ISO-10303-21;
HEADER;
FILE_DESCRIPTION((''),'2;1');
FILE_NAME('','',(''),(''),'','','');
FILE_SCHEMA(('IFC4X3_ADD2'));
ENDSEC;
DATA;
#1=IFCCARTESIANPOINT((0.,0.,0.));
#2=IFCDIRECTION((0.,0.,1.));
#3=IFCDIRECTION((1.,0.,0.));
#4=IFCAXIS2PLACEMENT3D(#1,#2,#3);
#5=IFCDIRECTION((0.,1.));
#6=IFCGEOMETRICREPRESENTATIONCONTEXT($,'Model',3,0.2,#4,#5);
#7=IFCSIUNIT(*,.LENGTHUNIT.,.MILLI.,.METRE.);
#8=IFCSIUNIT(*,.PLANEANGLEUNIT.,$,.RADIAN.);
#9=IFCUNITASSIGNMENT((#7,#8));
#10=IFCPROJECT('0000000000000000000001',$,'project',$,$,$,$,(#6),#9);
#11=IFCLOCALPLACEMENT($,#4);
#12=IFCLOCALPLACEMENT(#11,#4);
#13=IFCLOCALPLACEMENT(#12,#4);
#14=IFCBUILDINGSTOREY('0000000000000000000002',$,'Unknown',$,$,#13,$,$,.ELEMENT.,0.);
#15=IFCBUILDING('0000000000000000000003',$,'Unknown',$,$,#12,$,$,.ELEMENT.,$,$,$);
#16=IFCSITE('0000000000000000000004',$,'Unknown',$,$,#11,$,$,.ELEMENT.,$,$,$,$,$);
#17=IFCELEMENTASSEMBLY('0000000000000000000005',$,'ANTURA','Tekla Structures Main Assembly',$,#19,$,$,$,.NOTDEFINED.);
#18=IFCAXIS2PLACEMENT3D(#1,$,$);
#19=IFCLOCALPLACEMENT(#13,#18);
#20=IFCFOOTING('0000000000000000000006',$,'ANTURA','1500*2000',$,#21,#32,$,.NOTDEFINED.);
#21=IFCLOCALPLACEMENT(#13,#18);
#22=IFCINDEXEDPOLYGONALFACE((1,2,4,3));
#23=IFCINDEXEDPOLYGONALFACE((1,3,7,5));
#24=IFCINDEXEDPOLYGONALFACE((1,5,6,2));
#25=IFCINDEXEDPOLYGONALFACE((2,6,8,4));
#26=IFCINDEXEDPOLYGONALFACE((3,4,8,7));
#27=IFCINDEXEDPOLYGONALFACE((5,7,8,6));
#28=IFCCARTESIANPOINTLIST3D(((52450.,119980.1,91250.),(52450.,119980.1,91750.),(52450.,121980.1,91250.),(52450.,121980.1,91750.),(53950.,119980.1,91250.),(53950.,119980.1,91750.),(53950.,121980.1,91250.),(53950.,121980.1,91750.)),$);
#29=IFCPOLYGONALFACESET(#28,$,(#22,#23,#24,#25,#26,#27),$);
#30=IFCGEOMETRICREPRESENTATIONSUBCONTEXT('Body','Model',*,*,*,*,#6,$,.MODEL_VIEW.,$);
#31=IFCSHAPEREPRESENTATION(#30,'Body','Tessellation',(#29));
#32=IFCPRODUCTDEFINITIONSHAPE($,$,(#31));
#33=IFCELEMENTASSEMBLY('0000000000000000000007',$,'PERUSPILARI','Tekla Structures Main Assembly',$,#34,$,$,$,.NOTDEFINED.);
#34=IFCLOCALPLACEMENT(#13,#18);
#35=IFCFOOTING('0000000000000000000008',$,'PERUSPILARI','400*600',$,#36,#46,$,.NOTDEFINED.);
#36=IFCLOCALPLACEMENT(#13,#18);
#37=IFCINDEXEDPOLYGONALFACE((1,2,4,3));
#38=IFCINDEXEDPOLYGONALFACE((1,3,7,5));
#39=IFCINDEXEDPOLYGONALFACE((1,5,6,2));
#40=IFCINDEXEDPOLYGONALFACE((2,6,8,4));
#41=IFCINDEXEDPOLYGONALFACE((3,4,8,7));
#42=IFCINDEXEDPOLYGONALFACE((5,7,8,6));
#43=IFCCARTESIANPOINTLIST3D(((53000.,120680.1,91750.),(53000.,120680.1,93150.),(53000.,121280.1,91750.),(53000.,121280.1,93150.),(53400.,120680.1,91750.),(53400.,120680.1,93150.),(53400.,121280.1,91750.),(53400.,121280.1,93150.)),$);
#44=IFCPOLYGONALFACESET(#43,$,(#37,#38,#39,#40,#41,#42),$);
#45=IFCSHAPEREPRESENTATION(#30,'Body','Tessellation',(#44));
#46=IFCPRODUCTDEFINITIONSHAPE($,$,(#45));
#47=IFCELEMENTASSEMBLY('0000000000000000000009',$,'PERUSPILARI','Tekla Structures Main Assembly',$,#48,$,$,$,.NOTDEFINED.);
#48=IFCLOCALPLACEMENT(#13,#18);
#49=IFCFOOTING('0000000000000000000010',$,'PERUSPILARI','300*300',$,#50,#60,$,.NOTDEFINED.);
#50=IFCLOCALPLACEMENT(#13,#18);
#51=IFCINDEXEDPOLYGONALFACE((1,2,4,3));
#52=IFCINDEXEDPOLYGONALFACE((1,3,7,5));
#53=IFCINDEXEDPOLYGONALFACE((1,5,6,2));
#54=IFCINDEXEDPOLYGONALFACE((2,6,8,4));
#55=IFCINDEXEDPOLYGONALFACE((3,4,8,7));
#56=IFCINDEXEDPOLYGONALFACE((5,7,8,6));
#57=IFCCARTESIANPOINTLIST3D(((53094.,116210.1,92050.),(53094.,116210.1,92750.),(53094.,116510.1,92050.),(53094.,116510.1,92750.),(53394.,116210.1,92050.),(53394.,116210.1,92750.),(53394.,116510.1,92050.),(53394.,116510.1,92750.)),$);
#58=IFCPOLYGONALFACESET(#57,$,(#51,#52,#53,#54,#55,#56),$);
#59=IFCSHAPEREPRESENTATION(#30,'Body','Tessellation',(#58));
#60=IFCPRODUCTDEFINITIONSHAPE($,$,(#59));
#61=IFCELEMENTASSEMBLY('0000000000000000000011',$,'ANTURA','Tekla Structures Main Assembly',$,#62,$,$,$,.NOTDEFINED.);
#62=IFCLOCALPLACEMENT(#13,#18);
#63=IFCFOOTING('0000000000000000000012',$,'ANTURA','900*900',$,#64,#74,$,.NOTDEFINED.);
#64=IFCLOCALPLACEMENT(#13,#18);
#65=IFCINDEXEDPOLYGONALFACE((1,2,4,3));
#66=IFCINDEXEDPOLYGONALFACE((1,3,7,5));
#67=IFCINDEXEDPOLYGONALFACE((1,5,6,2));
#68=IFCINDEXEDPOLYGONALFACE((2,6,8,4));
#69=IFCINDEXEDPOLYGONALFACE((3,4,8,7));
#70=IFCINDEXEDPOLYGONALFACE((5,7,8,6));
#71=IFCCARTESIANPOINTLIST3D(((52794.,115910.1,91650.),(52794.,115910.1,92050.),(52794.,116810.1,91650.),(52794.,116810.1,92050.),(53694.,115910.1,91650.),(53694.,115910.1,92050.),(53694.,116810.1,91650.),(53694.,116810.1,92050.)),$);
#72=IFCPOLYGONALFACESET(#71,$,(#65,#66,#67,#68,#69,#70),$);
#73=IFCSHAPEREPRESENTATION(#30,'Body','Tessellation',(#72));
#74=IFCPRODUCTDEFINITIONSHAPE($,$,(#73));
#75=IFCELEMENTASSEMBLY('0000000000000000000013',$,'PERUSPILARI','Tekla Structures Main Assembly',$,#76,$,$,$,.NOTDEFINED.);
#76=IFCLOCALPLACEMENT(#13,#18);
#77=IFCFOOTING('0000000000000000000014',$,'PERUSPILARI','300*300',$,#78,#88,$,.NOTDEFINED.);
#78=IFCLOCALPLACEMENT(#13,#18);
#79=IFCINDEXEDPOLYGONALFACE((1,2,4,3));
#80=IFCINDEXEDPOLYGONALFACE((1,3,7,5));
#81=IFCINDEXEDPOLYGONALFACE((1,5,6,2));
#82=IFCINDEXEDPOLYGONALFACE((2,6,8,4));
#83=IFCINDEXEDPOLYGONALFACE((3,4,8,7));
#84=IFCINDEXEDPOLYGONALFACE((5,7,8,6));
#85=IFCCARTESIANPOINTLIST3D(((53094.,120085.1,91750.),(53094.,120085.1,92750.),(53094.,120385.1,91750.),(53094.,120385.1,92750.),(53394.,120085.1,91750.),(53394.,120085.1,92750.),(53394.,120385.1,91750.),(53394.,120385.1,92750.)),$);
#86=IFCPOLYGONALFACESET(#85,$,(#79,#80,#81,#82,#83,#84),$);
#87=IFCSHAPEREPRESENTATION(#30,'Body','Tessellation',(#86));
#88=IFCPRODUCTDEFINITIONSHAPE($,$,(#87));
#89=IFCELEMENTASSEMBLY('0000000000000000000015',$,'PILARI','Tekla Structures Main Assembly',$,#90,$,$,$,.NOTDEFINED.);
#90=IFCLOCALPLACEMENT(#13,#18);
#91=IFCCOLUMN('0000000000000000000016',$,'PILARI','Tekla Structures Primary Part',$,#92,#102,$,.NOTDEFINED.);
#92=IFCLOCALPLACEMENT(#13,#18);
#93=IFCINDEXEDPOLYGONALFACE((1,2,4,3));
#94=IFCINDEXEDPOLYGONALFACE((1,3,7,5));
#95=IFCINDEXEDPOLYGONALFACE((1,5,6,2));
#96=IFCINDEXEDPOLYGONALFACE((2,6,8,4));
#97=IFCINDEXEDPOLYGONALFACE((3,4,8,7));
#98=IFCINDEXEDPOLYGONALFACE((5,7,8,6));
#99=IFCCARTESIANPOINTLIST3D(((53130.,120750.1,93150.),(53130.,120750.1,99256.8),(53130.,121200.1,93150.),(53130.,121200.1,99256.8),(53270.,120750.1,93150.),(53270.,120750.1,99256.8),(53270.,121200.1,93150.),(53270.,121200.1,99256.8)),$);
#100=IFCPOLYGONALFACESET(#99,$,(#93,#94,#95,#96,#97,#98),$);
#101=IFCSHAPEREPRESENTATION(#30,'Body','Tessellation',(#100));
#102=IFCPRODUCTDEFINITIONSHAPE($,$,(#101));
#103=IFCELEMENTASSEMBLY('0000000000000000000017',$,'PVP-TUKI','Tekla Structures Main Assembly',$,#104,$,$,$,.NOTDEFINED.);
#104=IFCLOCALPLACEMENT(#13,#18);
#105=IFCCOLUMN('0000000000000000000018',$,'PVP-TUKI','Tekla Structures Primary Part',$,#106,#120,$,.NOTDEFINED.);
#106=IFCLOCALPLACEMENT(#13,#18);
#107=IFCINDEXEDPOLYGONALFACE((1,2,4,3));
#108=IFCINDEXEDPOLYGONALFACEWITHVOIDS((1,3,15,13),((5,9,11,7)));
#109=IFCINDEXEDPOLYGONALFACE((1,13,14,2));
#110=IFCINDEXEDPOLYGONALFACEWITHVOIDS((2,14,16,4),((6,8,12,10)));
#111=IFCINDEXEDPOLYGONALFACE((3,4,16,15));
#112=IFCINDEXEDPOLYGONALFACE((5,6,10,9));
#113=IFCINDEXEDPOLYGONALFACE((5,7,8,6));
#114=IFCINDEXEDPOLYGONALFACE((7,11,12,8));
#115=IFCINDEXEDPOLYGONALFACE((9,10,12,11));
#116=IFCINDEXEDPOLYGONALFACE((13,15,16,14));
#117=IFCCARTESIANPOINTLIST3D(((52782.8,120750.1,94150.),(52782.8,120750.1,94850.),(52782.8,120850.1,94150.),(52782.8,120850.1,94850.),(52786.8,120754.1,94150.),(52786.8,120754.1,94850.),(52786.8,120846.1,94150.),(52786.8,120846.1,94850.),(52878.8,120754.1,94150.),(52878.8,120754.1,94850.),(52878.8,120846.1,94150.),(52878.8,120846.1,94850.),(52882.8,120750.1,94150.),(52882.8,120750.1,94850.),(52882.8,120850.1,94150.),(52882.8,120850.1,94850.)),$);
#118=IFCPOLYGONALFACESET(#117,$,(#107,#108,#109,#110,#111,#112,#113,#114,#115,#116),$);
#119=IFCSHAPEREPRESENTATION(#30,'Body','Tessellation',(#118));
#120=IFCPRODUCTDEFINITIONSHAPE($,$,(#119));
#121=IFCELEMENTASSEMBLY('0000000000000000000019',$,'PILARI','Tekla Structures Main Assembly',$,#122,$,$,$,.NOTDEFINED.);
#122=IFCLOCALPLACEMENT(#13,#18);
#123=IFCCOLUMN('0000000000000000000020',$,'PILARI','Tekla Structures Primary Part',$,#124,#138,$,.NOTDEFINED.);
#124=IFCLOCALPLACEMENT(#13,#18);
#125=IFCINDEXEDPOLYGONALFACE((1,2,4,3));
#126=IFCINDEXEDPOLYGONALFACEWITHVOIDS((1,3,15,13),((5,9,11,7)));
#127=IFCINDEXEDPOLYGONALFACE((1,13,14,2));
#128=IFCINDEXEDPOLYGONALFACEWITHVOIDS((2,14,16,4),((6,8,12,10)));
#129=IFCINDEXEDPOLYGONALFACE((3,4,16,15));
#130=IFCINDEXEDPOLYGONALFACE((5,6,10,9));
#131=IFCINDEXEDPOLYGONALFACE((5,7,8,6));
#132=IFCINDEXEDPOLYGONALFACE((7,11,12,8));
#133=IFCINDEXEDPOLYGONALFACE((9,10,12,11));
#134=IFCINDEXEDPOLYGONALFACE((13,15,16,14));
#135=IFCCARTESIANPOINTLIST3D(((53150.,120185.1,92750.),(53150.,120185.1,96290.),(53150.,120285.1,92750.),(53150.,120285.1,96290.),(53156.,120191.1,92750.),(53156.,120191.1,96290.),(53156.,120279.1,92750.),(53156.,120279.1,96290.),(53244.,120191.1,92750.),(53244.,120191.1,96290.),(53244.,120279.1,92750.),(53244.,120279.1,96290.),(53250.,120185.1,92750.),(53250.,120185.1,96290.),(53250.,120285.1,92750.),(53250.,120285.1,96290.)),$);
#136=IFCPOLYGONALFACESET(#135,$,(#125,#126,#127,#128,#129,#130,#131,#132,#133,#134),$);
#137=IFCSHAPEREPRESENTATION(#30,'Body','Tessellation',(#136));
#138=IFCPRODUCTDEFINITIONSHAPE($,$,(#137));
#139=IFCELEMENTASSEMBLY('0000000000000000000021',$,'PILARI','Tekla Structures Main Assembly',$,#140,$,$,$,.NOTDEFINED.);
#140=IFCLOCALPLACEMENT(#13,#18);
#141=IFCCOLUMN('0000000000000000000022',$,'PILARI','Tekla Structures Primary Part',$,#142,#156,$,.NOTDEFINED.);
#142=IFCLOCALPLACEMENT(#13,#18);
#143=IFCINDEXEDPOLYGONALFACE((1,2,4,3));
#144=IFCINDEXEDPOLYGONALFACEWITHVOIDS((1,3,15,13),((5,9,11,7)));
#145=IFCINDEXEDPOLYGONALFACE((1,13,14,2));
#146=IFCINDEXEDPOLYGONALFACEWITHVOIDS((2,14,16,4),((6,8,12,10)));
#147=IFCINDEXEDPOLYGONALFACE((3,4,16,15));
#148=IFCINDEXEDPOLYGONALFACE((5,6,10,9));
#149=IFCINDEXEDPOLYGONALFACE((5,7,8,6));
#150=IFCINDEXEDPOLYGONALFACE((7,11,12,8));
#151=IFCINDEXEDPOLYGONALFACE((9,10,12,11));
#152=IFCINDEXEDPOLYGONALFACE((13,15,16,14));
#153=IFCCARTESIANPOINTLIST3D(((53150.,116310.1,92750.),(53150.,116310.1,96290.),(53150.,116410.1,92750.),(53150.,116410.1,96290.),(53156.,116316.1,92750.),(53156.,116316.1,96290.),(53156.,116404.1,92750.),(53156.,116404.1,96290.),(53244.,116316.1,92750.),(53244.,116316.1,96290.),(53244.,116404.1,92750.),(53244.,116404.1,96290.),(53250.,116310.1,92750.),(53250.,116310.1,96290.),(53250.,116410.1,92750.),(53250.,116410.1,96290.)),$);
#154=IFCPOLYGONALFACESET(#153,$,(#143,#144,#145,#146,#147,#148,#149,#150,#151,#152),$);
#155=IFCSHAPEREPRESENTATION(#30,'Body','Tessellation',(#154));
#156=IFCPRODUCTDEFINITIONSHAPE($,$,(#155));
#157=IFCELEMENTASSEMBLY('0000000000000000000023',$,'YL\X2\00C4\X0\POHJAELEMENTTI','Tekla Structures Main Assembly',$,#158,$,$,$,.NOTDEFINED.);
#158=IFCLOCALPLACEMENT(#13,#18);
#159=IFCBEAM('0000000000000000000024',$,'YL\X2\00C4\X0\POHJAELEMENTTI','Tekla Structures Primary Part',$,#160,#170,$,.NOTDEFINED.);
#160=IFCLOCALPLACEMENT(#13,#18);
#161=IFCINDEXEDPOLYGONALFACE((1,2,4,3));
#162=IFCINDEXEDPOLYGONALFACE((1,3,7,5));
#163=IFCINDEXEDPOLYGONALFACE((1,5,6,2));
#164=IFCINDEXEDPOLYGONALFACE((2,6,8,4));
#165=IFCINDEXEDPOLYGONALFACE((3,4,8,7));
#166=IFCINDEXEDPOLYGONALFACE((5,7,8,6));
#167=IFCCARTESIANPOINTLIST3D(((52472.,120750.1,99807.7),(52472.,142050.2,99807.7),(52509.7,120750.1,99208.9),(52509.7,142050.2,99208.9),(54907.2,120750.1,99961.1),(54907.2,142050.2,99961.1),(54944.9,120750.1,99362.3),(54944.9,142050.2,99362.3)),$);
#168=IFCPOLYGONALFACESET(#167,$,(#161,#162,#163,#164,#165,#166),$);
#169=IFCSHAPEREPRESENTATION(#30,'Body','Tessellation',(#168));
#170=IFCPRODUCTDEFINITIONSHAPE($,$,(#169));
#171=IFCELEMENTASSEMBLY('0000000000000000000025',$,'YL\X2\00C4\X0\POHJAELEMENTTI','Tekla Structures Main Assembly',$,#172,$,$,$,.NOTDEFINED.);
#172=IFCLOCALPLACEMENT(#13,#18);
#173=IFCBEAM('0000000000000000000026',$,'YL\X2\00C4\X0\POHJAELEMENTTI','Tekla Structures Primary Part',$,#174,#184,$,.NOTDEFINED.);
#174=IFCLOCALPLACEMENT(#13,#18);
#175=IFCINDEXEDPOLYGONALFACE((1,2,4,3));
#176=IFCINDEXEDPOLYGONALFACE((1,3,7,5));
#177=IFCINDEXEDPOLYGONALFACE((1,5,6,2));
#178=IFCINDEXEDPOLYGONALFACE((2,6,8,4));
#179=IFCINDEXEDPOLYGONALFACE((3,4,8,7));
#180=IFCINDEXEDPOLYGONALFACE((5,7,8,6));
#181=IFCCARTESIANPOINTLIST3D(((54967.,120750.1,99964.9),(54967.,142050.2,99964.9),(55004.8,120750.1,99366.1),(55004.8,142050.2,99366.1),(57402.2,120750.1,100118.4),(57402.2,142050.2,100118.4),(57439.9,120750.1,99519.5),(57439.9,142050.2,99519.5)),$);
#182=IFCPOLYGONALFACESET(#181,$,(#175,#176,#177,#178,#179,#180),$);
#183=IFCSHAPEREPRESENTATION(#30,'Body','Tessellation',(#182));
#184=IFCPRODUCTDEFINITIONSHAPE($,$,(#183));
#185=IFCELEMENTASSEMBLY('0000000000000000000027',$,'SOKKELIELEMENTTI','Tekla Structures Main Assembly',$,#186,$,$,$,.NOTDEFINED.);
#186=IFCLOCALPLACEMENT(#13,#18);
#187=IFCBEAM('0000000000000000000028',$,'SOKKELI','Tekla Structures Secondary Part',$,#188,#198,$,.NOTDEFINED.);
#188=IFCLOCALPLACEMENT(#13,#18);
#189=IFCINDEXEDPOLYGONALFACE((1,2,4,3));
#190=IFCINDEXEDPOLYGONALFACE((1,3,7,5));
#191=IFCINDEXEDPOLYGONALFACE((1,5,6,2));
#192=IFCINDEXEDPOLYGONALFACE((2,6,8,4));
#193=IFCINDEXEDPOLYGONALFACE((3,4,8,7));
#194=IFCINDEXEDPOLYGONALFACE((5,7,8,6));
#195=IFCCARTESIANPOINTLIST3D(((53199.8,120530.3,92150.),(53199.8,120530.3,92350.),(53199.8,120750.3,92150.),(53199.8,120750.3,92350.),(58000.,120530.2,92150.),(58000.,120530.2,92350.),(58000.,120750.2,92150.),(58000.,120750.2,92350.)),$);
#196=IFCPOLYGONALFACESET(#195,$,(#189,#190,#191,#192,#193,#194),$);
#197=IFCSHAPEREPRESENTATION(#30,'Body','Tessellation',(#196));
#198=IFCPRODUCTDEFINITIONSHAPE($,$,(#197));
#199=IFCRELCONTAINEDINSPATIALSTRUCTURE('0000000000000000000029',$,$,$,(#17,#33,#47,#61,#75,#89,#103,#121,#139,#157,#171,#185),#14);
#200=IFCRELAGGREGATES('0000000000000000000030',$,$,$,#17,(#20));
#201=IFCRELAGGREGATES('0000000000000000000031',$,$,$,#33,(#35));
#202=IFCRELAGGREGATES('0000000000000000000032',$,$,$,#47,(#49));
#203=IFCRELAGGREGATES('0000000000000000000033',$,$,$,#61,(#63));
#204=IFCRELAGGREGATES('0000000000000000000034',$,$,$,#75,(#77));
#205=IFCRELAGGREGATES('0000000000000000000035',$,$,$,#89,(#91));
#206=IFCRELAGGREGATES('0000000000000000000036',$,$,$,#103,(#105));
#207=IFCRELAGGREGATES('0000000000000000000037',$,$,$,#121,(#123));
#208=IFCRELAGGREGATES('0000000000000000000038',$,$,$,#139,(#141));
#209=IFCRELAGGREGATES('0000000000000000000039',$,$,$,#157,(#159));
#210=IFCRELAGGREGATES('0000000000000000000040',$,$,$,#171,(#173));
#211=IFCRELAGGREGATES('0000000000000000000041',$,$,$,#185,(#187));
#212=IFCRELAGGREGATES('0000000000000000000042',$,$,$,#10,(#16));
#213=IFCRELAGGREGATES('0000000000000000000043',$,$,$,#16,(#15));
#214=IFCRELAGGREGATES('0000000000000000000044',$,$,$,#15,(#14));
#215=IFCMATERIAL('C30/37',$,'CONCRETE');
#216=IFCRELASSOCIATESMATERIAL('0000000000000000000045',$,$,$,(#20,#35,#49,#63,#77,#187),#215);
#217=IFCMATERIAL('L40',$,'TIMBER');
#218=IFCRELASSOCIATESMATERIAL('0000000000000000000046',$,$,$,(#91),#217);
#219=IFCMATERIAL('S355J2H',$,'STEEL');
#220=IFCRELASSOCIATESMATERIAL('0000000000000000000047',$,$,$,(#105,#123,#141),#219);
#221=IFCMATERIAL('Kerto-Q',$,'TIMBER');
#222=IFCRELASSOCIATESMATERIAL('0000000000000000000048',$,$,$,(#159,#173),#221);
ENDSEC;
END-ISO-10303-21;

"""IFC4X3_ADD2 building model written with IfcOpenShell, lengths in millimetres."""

from ifc_helpers import new_model, si_unit, direction, frame, origin_with_axes, place, context, subcontext, project, spatial, line, indexed_curve, outline, extrude, material, element, aggregate, save


model = new_model("IFC4X3_ADD2")

# Units and contexts
model_context = context("Model", 3, precision=0.2, world=origin_with_axes(), true_north=direction((0.0, 1.0)))
body_context = subcontext(model_context, "Body", "Model", "MODEL_VIEW")
ifc_project = project(units=[si_unit("LENGTHUNIT", "METRE", prefix="MILLI"), si_unit("PLANEANGLEUNIT", "RADIAN")], contexts=[model_context])

# Site, building, storey
site_placement = place(None, origin_with_axes())
site = spatial("IfcSite", under=ifc_project, at=site_placement, Name="Unknown", CompositionType="ELEMENT")
building_placement = place(site_placement, origin_with_axes())
building = spatial("IfcBuilding", under=site, at=building_placement, Name="Unknown", CompositionType="ELEMENT")
storey_placement = place(building_placement, origin_with_axes())
storey = spatial("IfcBuildingStorey", under=building, at=storey_placement, Name="Unknown", CompositionType="ELEMENT", Elevation=0.0)

# Element assembly, footing
assembly_1_placement = place(storey_placement, frame((53200.0, 120980.1, 91250.0), z_axis=(0.0, -1.0, 0.0), x_axis=(0.0, 0.0, 1.0)))
assembly_1 = element("IfcElementAssembly", 1, at=assembly_1_placement, inside=storey, Name="ANTURA", Description="Tekla Structures Main Assembly", PredefinedType="NOTDEFINED")
ifc_material_1 = material(Name="C30/37", Category="CONCRETE")
footing_1_placement = place(assembly_1_placement, origin_with_axes())
footing_1 = element("IfcFooting", 2, at=footing_1_placement, material=ifc_material_1, Name="ANTURA", Description="1500*2000", PredefinedType="NOTDEFINED", context=body_context, shape_type="SolidModel", body=[
    extrude(outline(indexed_curve([(-1000.0, -750.0), (1000.0, -750.0), (1000.0, 750.0), (-1000.0, 750.0)], segments=[line(1, 2, 3, 4, 1)])), frame((0.0, 0.0, 0.0), z_axis=(-1.0, 0.0, 0.0), x_axis=(0.0, 0.0, 1.0)), (0.0, 0.0, -1.0), 500.0),
])
aggregate(assembly_1, [footing_1])

# Element assemblies, footings
assembly_2_placement = place(storey_placement, frame((53200.0, 120980.1, 91750.0), z_axis=(0.0, -1.0, 0.0), x_axis=(0.0, 0.0, 1.0)))
assembly_2 = element("IfcElementAssembly", 3, at=assembly_2_placement, inside=storey, Name="PERUSPILARI", Description="Tekla Structures Main Assembly", PredefinedType="NOTDEFINED")
footing_2_placement = place(assembly_2_placement, origin_with_axes())
footing_2 = element("IfcFooting", 4, at=footing_2_placement, material=ifc_material_1, Name="PERUSPILARI", Description="400*600", PredefinedType="NOTDEFINED", context=body_context, shape_type="SolidModel", body=[
    extrude(outline(indexed_curve([(-300.0, -200.0), (300.0, -200.0), (300.0, 200.0), (-300.0, 200.0)], segments=[line(1, 2, 3, 4, 1)])), frame((0.0, 0.0, 0.0), z_axis=(-1.0, 0.0, 0.0), x_axis=(0.0, 0.0, 1.0)), (0.0, 0.0, -1.0), 1400.0),
])
aggregate(assembly_2, [footing_2])
assembly_3_placement = place(storey_placement, frame((53244.0, 116360.1, 92050.0), z_axis=(-1.0, 0.0, 0.0), x_axis=(0.0, 0.0, 1.0)))
assembly_3 = element("IfcElementAssembly", 5, at=assembly_3_placement, inside=storey, Name="PERUSPILARI", Description="Tekla Structures Main Assembly", PredefinedType="NOTDEFINED")
footing_3_placement = place(assembly_3_placement, origin_with_axes())
footing_3 = element("IfcFooting", 6, at=footing_3_placement, material=ifc_material_1, Name="PERUSPILARI", Description="300*300", PredefinedType="NOTDEFINED", context=body_context, shape_type="SolidModel", body=[
    extrude(outline(indexed_curve([(-150.0, -150.0), (150.0, -150.0), (150.0, 150.0), (-150.0, 150.0)], segments=[line(1, 2, 3, 4, 1)])), frame((0.0, 0.0, 0.0), z_axis=(-1.0, 0.0, 0.0), x_axis=(0.0, 0.0, 1.0)), (0.0, 0.0, -1.0), 700.0),
])
aggregate(assembly_3, [footing_3])
assembly_4_placement = place(storey_placement, frame((53244.0, 116360.1, 91650.0), z_axis=(-1.0, 0.0, 0.0), x_axis=(0.0, 0.0, 1.0)))
assembly_4 = element("IfcElementAssembly", 7, at=assembly_4_placement, inside=storey, Name="ANTURA", Description="Tekla Structures Main Assembly", PredefinedType="NOTDEFINED")
footing_4_placement = place(assembly_4_placement, origin_with_axes())
footing_4 = element("IfcFooting", 8, at=footing_4_placement, material=ifc_material_1, Name="ANTURA", Description="900*900", PredefinedType="NOTDEFINED", context=body_context, shape_type="SolidModel", body=[
    extrude(outline(indexed_curve([(-450.0, -450.0), (450.0, -450.0), (450.0, 450.0), (-450.0, 450.0)], segments=[line(1, 2, 3, 4, 1)])), frame((0.0, 0.0, 0.0), z_axis=(-1.0, 0.0, 0.0), x_axis=(0.0, 0.0, 1.0)), (0.0, 0.0, -1.0), 400.0),
])
aggregate(assembly_4, [footing_4])
assembly_5_placement = place(storey_placement, frame((53244.0, 120235.1, 91750.0), z_axis=(-1.0, 0.0, 0.0), x_axis=(0.0, 0.0, 1.0)))
assembly_5 = element("IfcElementAssembly", 9, at=assembly_5_placement, inside=storey, Name="PERUSPILARI", Description="Tekla Structures Main Assembly", PredefinedType="NOTDEFINED")
footing_5_placement = place(assembly_5_placement, origin_with_axes())
footing_5 = element("IfcFooting", 10, at=footing_5_placement, material=ifc_material_1, Name="PERUSPILARI", Description="300*300", PredefinedType="NOTDEFINED", context=body_context, shape_type="SolidModel", body=[
    extrude(outline(indexed_curve([(-150.0, -150.0), (150.0, -150.0), (150.0, 150.0), (-150.0, 150.0)], segments=[line(1, 2, 3, 4, 1)])), frame((0.0, 0.0, 0.0), z_axis=(-1.0, 0.0, 0.0), x_axis=(0.0, 0.0, 1.0)), (0.0, 0.0, -1.0), 1000.0),
])
aggregate(assembly_5, [footing_5])

# Element assemblies, columns
assembly_6_placement = place(storey_placement, frame((53200.0, 120975.1, 93150.0), z_axis=(0.0, -1.0, 0.0), x_axis=(0.0, 0.0, 1.0)))
assembly_6 = element("IfcElementAssembly", 11, at=assembly_6_placement, inside=storey, Name="PILARI", Description="Tekla Structures Main Assembly", PredefinedType="NOTDEFINED")
ifc_material_2 = material(Name="L40", Category="TIMBER")
column_1_placement = place(assembly_6_placement, origin_with_axes())
column_1 = element("IfcColumn", 12, at=column_1_placement, material=ifc_material_2, Name="PILARI", Description="Tekla Structures Primary Part", PredefinedType="NOTDEFINED", context=body_context, shape_type="SolidModel", body=[
    extrude(outline(indexed_curve([(-225.0, -70.0), (225.0, -70.0), (225.0, 70.0), (-225.0, 70.0)], segments=[line(1, 2, 3, 4, 1)])), frame((0.0, 0.0, 0.0), z_axis=(-1.0, 0.0, 0.0), x_axis=(0.0, 0.0, 1.0)), (0.0, 0.0, -1.0), 6106.8),
])
aggregate(assembly_6, [column_1])
assembly_7_placement = place(storey_placement, frame((52832.8, 120800.1, 94150.0), z_axis=(-1.0, 0.0, 0.0), x_axis=(0.0, 0.0, 1.0)))
assembly_7 = element("IfcElementAssembly", 13, at=assembly_7_placement, inside=storey, Name="PVP-TUKI", Description="Tekla Structures Main Assembly", PredefinedType="NOTDEFINED")
ifc_material_3 = material(Name="S355J2H", Category="STEEL")
column_2_placement = place(assembly_7_placement, origin_with_axes())
column_2 = element("IfcColumn", 14, at=column_2_placement, material=ifc_material_3, Name="PVP-TUKI", Description="Tekla Structures Primary Part", PredefinedType="NOTDEFINED", context=body_context, shape_type="SolidModel", body=[
    extrude(outline(indexed_curve([(-50.0, -50.0), (50.0, -50.0), (50.0, 50.0), (-50.0, 50.0)], segments=[line(1, 2, 3, 4, 1)]), holes=[indexed_curve([(-46.0, -46.0), (-46.0, 46.0), (46.0, 46.0), (46.0, -46.0)], segments=[line(1, 2, 3, 4, 1)])]), frame((0.0, 0.0, 0.0), z_axis=(-1.0, 0.0, 0.0), x_axis=(0.0, 0.0, 1.0)), (0.0, 0.0, -1.0), 700.0),
])
aggregate(assembly_7, [column_2])
assembly_8_placement = place(storey_placement, frame((53200.0, 120235.1, 92750.0), z_axis=(0.0, -1.0, 0.0), x_axis=(0.0, 0.0, 1.0)))
assembly_8 = element("IfcElementAssembly", 15, at=assembly_8_placement, inside=storey, Name="PILARI", Description="Tekla Structures Main Assembly", PredefinedType="NOTDEFINED")
column_3_placement = place(assembly_8_placement, origin_with_axes())
column_3 = element("IfcColumn", 16, at=column_3_placement, material=ifc_material_3, Name="PILARI", Description="Tekla Structures Primary Part", PredefinedType="NOTDEFINED", context=body_context, shape_type="SolidModel", body=[
    extrude(outline(indexed_curve([(-50.0, -50.0), (50.0, -50.0), (50.0, 50.0), (-50.0, 50.0)], segments=[line(1, 2, 3, 4, 1)]), holes=[indexed_curve([(-44.0, -44.0), (-44.0, 44.0), (44.0, 44.0), (44.0, -44.0)], segments=[line(1, 2, 3, 4, 1)])]), frame((0.0, 0.0, 0.0), z_axis=(-1.0, 0.0, 0.0), x_axis=(0.0, 0.0, 1.0)), (0.0, 0.0, -1.0), 3540.0),
])
aggregate(assembly_8, [column_3])
assembly_9_placement = place(storey_placement, frame((53200.0, 116360.1, 92750.0), z_axis=(0.0, -1.0, 0.0), x_axis=(0.0, 0.0, 1.0)))
assembly_9 = element("IfcElementAssembly", 17, at=assembly_9_placement, inside=storey, Name="PILARI", Description="Tekla Structures Main Assembly", PredefinedType="NOTDEFINED")
column_4_placement = place(assembly_9_placement, origin_with_axes())
column_4 = element("IfcColumn", 18, at=column_4_placement, material=ifc_material_3, Name="PILARI", Description="Tekla Structures Primary Part", PredefinedType="NOTDEFINED", context=body_context, shape_type="SolidModel", body=[
    extrude(outline(indexed_curve([(-50.0, -50.0), (50.0, -50.0), (50.0, 50.0), (-50.0, 50.0)], segments=[line(1, 2, 3, 4, 1)]), holes=[indexed_curve([(-44.0, -44.0), (-44.0, 44.0), (44.0, 44.0), (44.0, -44.0)], segments=[line(1, 2, 3, 4, 1)])]), frame((0.0, 0.0, 0.0), z_axis=(-1.0, 0.0, 0.0), x_axis=(0.0, 0.0, 1.0)), (0.0, 0.0, -1.0), 3540.0),
])
aggregate(assembly_9, [column_4])

# Element assemblies, beams
assembly_10_placement = place(storey_placement, frame((53708.4, 120750.1, 99585.0), z_axis=(-0.062892, 0.0, 0.99802), x_axis=(0.0, 1.0, 0.0)))
assembly_10 = element("IfcElementAssembly", 19, at=assembly_10_placement, inside=storey, Name="YLÄPOHJAELEMENTTI", Description="Tekla Structures Main Assembly", PredefinedType="NOTDEFINED")
ifc_material_4 = material(Name="Kerto-Q", Category="TIMBER")
beam_1_placement = place(assembly_10_placement, origin_with_axes())
beam_1 = element("IfcBeam", 20, at=beam_1_placement, material=ifc_material_4, Name="YLÄPOHJAELEMENTTI", Description="Tekla Structures Primary Part", PredefinedType="NOTDEFINED", context=body_context, shape_type="SolidModel", body=[
    extrude(outline(indexed_curve([(-300.0, -1220.0), (300.0, -1220.0), (300.0, 1220.0), (-300.0, 1220.0)], segments=[line(1, 2, 3, 4, 1)])), frame((0.0, 0.0, 0.0), z_axis=(-1.0, 0.0, 0.0), x_axis=(0.0, 0.0, 1.0)), (0.0, 0.0, -1.0), 21300.0),
])
aggregate(assembly_10, [beam_1])
assembly_11_placement = place(storey_placement, frame((56203.5, 120750.1, 99742.2), z_axis=(-0.062892, 0.0, 0.99802), x_axis=(0.0, 1.0, 0.0)))
assembly_11 = element("IfcElementAssembly", 21, at=assembly_11_placement, inside=storey, Name="YLÄPOHJAELEMENTTI", Description="Tekla Structures Main Assembly", PredefinedType="NOTDEFINED")
beam_2_placement = place(assembly_11_placement, origin_with_axes())
beam_2 = element("IfcBeam", 22, at=beam_2_placement, material=ifc_material_4, Name="YLÄPOHJAELEMENTTI", Description="Tekla Structures Primary Part", PredefinedType="NOTDEFINED", context=body_context, shape_type="SolidModel", body=[
    extrude(outline(indexed_curve([(-300.0, -1220.0), (300.0, -1220.0), (300.0, 1220.0), (-300.0, 1220.0)], segments=[line(1, 2, 3, 4, 1)])), frame((0.0, 0.0, 0.0), z_axis=(-1.0, 0.0, 0.0), x_axis=(0.0, 0.0, 1.0)), (0.0, 0.0, -1.0), 21300.0),
])
aggregate(assembly_11, [beam_2])

# Element assembly, beam
assembly_12_placement = place(storey_placement, frame((58000.0, 120810.2, 93150.0), z_axis=(0.000027, 1.0, 0.0), x_axis=(-1.0, 0.000027, 0.0)))
assembly_12 = element("IfcElementAssembly", 23, at=assembly_12_placement, inside=storey, Name="SOKKELIELEMENTTI", Description="Tekla Structures Main Assembly", PredefinedType="NOTDEFINED")
beam_3_placement = place(assembly_12_placement, frame((0.0, -900.0, -170.0), z_axis=(0.0, 0.0, 1.0), x_axis=(1.0, 0.0, 0.0)))
beam_3 = element("IfcBeam", 24, at=beam_3_placement, material=ifc_material_1, Name="SOKKELI", Description="Tekla Structures Secondary Part", PredefinedType="NOTDEFINED", context=body_context, shape_type="SolidModel", body=[
    extrude(outline(indexed_curve([(-110.0, -100.0), (110.0, -100.0), (110.0, 100.0), (-110.0, 100.0)], segments=[line(1, 2, 3, 4, 1)])), frame((0.0, 0.0, 0.0), z_axis=(-1.0, 0.0, 0.0), x_axis=(0.0, 0.0, 1.0)), (0.0, 0.0, -1.0), 4800.1),
])
aggregate(assembly_12, [beam_3])

save(model, "model.ifc")
